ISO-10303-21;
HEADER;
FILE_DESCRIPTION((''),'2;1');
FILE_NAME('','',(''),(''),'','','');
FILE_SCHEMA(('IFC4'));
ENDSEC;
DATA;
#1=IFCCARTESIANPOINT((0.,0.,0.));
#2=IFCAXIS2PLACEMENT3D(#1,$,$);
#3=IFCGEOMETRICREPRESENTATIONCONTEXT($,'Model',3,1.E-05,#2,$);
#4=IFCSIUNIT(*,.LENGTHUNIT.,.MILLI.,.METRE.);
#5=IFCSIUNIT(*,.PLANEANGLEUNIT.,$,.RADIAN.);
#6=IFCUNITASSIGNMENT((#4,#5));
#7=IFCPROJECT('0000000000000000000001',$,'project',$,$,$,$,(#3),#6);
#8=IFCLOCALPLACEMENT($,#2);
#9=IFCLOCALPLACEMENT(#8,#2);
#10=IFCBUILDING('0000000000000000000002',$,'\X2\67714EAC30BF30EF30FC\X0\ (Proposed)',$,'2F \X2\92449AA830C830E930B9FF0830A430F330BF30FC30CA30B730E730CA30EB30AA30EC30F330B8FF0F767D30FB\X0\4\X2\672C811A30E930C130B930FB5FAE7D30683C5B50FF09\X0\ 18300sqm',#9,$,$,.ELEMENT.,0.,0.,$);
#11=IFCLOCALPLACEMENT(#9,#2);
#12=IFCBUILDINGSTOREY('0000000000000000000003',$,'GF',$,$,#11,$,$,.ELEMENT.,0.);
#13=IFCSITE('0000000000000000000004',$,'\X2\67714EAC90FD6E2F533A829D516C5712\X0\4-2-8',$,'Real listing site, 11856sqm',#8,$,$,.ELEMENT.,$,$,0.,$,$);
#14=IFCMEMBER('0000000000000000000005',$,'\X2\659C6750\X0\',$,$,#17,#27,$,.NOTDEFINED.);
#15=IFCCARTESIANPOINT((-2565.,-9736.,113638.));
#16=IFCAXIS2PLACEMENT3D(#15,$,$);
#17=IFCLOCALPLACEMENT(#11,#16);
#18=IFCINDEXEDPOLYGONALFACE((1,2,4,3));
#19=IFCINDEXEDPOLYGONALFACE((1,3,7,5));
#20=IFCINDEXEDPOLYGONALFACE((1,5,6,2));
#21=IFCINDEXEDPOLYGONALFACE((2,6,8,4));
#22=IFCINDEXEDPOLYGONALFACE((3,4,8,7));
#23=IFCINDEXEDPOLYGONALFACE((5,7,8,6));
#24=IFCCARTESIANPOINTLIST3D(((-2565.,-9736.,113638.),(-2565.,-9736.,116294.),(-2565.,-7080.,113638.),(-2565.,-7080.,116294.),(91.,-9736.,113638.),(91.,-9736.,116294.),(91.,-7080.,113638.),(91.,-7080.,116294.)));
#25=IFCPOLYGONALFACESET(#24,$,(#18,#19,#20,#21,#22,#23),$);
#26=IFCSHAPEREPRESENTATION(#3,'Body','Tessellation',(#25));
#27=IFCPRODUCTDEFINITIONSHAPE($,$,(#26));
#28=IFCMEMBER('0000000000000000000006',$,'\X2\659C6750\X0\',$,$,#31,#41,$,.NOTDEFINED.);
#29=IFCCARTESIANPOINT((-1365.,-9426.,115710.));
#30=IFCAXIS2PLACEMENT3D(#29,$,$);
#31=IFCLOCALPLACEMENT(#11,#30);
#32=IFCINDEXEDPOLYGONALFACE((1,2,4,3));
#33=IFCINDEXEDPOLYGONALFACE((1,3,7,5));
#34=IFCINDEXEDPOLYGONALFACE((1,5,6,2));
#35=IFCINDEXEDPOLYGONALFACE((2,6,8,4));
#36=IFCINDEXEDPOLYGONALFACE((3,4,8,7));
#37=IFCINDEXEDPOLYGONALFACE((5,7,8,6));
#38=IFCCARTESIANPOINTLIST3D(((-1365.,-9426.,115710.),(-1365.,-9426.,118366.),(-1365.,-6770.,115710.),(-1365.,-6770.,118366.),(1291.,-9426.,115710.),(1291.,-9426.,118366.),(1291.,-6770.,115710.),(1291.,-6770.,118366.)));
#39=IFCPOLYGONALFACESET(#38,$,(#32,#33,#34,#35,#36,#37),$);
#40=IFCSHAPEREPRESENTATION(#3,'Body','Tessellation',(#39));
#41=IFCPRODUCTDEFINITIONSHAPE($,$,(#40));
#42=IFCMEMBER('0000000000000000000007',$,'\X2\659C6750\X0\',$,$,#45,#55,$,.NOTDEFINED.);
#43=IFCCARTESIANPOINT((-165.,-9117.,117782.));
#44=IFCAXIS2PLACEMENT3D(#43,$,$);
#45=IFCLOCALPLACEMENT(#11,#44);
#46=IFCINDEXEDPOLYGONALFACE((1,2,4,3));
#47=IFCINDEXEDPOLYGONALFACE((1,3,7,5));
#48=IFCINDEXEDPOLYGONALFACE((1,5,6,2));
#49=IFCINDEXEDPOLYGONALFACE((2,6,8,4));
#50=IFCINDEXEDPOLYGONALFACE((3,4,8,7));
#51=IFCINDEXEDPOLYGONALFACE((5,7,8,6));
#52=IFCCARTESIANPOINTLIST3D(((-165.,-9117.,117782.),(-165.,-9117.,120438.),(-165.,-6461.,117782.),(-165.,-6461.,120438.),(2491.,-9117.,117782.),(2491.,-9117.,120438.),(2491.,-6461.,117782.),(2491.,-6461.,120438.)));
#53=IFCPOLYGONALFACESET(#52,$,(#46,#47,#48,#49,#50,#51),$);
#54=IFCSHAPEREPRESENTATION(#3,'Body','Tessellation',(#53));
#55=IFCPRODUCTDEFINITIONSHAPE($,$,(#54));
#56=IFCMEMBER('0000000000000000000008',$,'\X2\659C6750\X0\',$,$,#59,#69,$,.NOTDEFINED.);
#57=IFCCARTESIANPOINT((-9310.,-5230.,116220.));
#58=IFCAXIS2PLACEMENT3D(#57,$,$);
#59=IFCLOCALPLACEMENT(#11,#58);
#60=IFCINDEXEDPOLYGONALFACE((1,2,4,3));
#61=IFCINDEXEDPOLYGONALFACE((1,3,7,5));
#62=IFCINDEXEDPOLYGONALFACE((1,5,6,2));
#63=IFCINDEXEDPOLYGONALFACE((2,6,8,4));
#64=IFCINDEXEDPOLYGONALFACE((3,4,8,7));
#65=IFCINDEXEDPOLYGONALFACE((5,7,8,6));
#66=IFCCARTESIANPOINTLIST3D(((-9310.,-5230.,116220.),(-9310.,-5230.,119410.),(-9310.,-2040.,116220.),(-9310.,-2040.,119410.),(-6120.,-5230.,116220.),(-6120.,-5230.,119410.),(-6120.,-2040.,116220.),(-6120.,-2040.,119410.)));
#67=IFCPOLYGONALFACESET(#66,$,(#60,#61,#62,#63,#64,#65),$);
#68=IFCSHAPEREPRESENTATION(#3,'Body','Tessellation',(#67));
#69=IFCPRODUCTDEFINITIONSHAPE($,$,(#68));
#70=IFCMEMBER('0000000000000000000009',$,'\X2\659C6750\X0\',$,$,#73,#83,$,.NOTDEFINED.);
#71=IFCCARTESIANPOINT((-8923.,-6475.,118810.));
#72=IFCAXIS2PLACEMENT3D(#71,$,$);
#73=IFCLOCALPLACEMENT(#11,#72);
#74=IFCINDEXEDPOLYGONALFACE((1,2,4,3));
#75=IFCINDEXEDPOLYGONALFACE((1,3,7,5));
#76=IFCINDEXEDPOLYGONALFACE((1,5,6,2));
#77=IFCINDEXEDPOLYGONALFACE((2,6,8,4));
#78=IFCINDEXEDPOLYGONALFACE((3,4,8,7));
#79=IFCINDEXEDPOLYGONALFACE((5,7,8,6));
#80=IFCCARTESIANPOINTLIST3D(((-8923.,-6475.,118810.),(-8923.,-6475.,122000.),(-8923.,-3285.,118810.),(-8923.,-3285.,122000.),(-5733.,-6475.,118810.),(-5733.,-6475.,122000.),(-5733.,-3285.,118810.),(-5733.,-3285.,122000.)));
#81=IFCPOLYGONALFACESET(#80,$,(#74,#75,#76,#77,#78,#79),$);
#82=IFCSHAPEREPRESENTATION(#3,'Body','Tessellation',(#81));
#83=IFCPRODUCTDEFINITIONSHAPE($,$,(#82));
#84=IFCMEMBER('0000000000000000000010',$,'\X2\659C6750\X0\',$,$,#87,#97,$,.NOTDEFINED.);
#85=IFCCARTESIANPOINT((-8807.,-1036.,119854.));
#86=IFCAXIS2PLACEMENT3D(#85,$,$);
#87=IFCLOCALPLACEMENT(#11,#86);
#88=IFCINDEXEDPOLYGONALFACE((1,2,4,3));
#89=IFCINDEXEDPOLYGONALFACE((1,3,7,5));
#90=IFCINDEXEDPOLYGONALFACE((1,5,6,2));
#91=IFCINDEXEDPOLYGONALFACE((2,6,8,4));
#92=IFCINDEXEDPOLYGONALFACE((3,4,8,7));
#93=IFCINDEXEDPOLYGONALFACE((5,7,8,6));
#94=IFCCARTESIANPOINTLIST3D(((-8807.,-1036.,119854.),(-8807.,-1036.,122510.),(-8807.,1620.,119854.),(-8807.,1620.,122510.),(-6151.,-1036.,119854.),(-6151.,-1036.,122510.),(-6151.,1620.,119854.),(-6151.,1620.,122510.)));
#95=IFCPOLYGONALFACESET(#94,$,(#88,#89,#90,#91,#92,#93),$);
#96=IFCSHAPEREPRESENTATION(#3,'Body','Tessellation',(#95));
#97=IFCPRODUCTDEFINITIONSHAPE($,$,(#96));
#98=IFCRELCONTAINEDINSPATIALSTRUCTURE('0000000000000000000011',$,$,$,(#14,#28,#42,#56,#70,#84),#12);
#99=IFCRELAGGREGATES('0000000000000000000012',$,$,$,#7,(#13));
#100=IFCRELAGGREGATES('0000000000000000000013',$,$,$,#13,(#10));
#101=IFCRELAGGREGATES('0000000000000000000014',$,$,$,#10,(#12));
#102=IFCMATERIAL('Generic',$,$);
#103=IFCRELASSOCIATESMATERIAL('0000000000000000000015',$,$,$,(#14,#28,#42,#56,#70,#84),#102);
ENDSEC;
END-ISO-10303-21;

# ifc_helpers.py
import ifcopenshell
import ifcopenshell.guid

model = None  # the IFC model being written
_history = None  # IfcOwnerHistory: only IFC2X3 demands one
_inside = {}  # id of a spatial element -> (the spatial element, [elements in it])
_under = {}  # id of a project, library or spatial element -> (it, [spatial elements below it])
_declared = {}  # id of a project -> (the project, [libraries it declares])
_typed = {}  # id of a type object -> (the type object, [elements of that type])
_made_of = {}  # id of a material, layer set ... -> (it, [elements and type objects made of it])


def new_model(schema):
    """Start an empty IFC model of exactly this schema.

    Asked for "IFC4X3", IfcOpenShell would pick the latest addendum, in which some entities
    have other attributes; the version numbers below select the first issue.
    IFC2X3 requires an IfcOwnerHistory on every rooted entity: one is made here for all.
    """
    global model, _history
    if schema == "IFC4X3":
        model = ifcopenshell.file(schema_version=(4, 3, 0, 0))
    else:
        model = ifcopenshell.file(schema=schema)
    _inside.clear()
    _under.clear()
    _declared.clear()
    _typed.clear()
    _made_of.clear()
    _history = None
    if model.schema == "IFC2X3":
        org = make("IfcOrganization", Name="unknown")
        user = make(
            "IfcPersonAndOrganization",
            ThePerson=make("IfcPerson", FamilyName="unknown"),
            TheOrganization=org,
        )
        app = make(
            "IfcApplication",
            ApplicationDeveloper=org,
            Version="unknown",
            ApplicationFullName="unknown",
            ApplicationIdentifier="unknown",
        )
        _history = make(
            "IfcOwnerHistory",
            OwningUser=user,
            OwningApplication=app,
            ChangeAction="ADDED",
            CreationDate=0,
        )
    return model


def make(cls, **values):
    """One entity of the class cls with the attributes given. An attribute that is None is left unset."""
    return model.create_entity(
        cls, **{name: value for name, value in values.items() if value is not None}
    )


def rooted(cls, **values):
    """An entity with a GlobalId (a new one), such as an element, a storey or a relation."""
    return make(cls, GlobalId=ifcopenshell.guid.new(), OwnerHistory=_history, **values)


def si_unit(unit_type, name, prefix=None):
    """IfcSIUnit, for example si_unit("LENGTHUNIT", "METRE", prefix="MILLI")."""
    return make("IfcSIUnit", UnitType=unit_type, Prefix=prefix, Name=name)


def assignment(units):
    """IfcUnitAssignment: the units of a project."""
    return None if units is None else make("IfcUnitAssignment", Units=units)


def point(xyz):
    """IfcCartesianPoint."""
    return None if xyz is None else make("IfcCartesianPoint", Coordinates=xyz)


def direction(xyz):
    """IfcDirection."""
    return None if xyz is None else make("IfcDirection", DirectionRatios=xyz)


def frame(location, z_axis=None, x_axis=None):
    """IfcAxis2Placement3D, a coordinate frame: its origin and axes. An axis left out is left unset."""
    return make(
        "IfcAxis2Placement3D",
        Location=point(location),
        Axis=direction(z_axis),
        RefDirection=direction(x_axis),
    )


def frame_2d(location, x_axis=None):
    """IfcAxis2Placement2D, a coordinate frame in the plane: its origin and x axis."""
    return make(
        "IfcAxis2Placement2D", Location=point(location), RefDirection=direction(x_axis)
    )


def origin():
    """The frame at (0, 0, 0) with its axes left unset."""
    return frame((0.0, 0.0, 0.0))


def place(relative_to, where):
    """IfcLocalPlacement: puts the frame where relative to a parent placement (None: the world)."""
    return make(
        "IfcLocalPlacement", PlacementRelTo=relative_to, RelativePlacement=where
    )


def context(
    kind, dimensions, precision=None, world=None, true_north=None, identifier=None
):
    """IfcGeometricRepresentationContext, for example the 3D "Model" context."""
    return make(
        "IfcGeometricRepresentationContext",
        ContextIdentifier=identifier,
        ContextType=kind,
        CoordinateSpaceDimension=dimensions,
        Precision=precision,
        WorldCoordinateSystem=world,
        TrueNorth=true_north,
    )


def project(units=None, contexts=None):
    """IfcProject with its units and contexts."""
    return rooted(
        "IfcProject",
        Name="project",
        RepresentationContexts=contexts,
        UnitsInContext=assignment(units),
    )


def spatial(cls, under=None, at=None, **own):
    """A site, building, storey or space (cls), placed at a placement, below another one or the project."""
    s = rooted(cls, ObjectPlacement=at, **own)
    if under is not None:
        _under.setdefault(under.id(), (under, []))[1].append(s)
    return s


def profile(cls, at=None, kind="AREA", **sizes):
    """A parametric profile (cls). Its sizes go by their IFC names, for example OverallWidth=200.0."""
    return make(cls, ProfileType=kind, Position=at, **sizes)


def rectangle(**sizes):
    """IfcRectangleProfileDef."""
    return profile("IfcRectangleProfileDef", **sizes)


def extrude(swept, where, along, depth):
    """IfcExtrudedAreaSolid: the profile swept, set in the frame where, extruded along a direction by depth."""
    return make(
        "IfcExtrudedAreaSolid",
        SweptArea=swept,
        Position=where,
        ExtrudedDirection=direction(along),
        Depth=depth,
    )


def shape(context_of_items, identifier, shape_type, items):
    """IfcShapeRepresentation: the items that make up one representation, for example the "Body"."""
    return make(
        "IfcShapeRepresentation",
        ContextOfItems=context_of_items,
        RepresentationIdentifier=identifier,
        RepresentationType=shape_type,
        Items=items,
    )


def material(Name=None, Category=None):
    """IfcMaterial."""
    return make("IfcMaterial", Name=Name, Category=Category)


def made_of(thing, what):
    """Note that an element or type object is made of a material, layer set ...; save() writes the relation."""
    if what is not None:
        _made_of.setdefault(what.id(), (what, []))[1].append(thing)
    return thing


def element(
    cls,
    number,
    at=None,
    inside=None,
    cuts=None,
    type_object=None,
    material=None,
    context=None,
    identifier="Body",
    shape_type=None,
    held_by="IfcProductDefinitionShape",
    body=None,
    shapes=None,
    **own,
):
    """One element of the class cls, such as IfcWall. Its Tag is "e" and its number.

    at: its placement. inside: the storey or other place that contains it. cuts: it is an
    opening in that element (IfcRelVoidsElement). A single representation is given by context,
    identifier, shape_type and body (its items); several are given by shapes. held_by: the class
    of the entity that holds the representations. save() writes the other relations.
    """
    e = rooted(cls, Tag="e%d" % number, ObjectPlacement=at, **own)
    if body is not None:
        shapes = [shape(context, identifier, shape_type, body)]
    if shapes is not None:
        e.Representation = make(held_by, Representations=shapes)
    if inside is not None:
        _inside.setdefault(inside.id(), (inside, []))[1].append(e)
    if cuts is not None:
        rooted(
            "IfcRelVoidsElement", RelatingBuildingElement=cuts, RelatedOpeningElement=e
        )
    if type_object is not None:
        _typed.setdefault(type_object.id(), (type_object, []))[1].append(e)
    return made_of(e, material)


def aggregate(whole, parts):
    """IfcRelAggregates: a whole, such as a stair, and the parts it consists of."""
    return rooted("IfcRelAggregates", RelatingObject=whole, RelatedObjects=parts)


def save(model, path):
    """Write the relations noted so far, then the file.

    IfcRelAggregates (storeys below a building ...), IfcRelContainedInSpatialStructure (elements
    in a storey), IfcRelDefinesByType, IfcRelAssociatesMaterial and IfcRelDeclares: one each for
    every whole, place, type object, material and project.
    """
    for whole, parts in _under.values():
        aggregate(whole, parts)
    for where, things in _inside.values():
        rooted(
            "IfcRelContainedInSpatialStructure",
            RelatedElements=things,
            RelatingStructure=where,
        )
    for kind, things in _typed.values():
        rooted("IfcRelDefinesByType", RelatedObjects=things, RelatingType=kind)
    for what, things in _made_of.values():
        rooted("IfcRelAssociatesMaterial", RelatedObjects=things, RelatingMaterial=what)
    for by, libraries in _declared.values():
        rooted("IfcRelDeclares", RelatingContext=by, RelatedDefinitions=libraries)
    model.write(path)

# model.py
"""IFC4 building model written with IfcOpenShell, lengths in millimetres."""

from ifc_helpers import new_model, si_unit, frame, frame_2d, origin, place, context, project, spatial, rectangle, extrude, material, element, save


model = new_model("IFC4")

# Units and contexts
model_context = context("Model", 3, precision=1e-05, world=origin())
ifc_project = project(units=[si_unit("LENGTHUNIT", "METRE", prefix="MILLI"), si_unit("PLANEANGLEUNIT", "RADIAN")], contexts=[model_context])

# Site, building, storey
site_placement = place(None, origin())
site = spatial("IfcSite", under=ifc_project, at=site_placement, Name="東京都港区芝公園4-2-8", ObjectType="Real listing site, 11856sqm", CompositionType="ELEMENT", RefElevation=0.0)
building_placement = place(site_placement, origin())
building = spatial("IfcBuilding", under=site, at=building_placement, Name="東京タワー (Proposed)", ObjectType="2F 鉄骨トラス（インターナショナルオレンジ／白・4本脚ラチス・微細格子） 18300sqm", CompositionType="ELEMENT", ElevationOfRefHeight=0.0, ElevationOfTerrain=0.0)
storey_placement = place(building_placement, origin())
storey = spatial("IfcBuildingStorey", under=building, at=storey_placement, Name="GF", CompositionType="ELEMENT", Elevation=0.0)

# Shared definitions
ifc_material = material(Name="Generic")

# Members
member_1_placement = place(storey_placement, frame((-2565.0, -9736.0, 113638.0)))
element("IfcMember", 1, at=member_1_placement, inside=storey, material=ifc_material, Name="斜材", PredefinedType="NOTDEFINED", context=model_context, shape_type="SweptSolid", body=[
    extrude(rectangle(XDim=2656.0, YDim=2656.0, at=frame_2d((1328.0, 1328.0))), frame((-2565.0, -9736.0, 113638.0)), (0.0, 0.0, 1.0), 2656.0),
])
member_2_placement = place(storey_placement, frame((-1365.0, -9426.0, 115710.0)))
element("IfcMember", 2, at=member_2_placement, inside=storey, material=ifc_material, Name="斜材", PredefinedType="NOTDEFINED", context=model_context, shape_type="SweptSolid", body=[
    extrude(rectangle(XDim=2656.0, YDim=2656.0, at=frame_2d((1328.0, 1328.0))), frame((-1365.0, -9426.0, 115710.0)), (0.0, 0.0, 1.0), 2656.0),
])
member_3_placement = place(storey_placement, frame((-165.0, -9117.0, 117782.0)))
element("IfcMember", 3, at=member_3_placement, inside=storey, material=ifc_material, Name="斜材", PredefinedType="NOTDEFINED", context=model_context, shape_type="SweptSolid", body=[
    extrude(rectangle(XDim=2656.0, YDim=2656.0, at=frame_2d((1328.0, 1328.0))), frame((-165.0, -9117.0, 117782.0)), (0.0, 0.0, 1.0), 2656.0),
])
member_4_placement = place(storey_placement, frame((-9310.0, -5230.0, 116220.0)))
element("IfcMember", 4, at=member_4_placement, inside=storey, material=ifc_material, Name="斜材", PredefinedType="NOTDEFINED", context=model_context, shape_type="SweptSolid", body=[
    extrude(rectangle(XDim=3190.0, YDim=3190.0, at=frame_2d((1595.0, 1595.0))), frame((-9310.0, -5230.0, 116220.0)), (0.0, 0.0, 1.0), 3190.0),
])
member_5_placement = place(storey_placement, frame((-8923.0, -6475.0, 118810.0)))
element("IfcMember", 5, at=member_5_placement, inside=storey, material=ifc_material, Name="斜材", PredefinedType="NOTDEFINED", context=model_context, shape_type="SweptSolid", body=[
    extrude(rectangle(XDim=3190.0, YDim=3190.0, at=frame_2d((1595.0, 1595.0))), frame((-8923.0, -6475.0, 118810.0)), (0.0, 0.0, 1.0), 3190.0),
])
member_6_placement = place(storey_placement, frame((-8807.0, -1036.0, 119854.0)))
element("IfcMember", 6, at=member_6_placement, inside=storey, material=ifc_material, Name="斜材", PredefinedType="NOTDEFINED", context=model_context, shape_type="SweptSolid", body=[
    extrude(rectangle(XDim=2656.0, YDim=2656.0, at=frame_2d((1328.0, 1328.0))), frame((-8807.0, -1036.0, 119854.0)), (0.0, 0.0, 1.0), 2656.0),
])

save(model, "model.ifc")
